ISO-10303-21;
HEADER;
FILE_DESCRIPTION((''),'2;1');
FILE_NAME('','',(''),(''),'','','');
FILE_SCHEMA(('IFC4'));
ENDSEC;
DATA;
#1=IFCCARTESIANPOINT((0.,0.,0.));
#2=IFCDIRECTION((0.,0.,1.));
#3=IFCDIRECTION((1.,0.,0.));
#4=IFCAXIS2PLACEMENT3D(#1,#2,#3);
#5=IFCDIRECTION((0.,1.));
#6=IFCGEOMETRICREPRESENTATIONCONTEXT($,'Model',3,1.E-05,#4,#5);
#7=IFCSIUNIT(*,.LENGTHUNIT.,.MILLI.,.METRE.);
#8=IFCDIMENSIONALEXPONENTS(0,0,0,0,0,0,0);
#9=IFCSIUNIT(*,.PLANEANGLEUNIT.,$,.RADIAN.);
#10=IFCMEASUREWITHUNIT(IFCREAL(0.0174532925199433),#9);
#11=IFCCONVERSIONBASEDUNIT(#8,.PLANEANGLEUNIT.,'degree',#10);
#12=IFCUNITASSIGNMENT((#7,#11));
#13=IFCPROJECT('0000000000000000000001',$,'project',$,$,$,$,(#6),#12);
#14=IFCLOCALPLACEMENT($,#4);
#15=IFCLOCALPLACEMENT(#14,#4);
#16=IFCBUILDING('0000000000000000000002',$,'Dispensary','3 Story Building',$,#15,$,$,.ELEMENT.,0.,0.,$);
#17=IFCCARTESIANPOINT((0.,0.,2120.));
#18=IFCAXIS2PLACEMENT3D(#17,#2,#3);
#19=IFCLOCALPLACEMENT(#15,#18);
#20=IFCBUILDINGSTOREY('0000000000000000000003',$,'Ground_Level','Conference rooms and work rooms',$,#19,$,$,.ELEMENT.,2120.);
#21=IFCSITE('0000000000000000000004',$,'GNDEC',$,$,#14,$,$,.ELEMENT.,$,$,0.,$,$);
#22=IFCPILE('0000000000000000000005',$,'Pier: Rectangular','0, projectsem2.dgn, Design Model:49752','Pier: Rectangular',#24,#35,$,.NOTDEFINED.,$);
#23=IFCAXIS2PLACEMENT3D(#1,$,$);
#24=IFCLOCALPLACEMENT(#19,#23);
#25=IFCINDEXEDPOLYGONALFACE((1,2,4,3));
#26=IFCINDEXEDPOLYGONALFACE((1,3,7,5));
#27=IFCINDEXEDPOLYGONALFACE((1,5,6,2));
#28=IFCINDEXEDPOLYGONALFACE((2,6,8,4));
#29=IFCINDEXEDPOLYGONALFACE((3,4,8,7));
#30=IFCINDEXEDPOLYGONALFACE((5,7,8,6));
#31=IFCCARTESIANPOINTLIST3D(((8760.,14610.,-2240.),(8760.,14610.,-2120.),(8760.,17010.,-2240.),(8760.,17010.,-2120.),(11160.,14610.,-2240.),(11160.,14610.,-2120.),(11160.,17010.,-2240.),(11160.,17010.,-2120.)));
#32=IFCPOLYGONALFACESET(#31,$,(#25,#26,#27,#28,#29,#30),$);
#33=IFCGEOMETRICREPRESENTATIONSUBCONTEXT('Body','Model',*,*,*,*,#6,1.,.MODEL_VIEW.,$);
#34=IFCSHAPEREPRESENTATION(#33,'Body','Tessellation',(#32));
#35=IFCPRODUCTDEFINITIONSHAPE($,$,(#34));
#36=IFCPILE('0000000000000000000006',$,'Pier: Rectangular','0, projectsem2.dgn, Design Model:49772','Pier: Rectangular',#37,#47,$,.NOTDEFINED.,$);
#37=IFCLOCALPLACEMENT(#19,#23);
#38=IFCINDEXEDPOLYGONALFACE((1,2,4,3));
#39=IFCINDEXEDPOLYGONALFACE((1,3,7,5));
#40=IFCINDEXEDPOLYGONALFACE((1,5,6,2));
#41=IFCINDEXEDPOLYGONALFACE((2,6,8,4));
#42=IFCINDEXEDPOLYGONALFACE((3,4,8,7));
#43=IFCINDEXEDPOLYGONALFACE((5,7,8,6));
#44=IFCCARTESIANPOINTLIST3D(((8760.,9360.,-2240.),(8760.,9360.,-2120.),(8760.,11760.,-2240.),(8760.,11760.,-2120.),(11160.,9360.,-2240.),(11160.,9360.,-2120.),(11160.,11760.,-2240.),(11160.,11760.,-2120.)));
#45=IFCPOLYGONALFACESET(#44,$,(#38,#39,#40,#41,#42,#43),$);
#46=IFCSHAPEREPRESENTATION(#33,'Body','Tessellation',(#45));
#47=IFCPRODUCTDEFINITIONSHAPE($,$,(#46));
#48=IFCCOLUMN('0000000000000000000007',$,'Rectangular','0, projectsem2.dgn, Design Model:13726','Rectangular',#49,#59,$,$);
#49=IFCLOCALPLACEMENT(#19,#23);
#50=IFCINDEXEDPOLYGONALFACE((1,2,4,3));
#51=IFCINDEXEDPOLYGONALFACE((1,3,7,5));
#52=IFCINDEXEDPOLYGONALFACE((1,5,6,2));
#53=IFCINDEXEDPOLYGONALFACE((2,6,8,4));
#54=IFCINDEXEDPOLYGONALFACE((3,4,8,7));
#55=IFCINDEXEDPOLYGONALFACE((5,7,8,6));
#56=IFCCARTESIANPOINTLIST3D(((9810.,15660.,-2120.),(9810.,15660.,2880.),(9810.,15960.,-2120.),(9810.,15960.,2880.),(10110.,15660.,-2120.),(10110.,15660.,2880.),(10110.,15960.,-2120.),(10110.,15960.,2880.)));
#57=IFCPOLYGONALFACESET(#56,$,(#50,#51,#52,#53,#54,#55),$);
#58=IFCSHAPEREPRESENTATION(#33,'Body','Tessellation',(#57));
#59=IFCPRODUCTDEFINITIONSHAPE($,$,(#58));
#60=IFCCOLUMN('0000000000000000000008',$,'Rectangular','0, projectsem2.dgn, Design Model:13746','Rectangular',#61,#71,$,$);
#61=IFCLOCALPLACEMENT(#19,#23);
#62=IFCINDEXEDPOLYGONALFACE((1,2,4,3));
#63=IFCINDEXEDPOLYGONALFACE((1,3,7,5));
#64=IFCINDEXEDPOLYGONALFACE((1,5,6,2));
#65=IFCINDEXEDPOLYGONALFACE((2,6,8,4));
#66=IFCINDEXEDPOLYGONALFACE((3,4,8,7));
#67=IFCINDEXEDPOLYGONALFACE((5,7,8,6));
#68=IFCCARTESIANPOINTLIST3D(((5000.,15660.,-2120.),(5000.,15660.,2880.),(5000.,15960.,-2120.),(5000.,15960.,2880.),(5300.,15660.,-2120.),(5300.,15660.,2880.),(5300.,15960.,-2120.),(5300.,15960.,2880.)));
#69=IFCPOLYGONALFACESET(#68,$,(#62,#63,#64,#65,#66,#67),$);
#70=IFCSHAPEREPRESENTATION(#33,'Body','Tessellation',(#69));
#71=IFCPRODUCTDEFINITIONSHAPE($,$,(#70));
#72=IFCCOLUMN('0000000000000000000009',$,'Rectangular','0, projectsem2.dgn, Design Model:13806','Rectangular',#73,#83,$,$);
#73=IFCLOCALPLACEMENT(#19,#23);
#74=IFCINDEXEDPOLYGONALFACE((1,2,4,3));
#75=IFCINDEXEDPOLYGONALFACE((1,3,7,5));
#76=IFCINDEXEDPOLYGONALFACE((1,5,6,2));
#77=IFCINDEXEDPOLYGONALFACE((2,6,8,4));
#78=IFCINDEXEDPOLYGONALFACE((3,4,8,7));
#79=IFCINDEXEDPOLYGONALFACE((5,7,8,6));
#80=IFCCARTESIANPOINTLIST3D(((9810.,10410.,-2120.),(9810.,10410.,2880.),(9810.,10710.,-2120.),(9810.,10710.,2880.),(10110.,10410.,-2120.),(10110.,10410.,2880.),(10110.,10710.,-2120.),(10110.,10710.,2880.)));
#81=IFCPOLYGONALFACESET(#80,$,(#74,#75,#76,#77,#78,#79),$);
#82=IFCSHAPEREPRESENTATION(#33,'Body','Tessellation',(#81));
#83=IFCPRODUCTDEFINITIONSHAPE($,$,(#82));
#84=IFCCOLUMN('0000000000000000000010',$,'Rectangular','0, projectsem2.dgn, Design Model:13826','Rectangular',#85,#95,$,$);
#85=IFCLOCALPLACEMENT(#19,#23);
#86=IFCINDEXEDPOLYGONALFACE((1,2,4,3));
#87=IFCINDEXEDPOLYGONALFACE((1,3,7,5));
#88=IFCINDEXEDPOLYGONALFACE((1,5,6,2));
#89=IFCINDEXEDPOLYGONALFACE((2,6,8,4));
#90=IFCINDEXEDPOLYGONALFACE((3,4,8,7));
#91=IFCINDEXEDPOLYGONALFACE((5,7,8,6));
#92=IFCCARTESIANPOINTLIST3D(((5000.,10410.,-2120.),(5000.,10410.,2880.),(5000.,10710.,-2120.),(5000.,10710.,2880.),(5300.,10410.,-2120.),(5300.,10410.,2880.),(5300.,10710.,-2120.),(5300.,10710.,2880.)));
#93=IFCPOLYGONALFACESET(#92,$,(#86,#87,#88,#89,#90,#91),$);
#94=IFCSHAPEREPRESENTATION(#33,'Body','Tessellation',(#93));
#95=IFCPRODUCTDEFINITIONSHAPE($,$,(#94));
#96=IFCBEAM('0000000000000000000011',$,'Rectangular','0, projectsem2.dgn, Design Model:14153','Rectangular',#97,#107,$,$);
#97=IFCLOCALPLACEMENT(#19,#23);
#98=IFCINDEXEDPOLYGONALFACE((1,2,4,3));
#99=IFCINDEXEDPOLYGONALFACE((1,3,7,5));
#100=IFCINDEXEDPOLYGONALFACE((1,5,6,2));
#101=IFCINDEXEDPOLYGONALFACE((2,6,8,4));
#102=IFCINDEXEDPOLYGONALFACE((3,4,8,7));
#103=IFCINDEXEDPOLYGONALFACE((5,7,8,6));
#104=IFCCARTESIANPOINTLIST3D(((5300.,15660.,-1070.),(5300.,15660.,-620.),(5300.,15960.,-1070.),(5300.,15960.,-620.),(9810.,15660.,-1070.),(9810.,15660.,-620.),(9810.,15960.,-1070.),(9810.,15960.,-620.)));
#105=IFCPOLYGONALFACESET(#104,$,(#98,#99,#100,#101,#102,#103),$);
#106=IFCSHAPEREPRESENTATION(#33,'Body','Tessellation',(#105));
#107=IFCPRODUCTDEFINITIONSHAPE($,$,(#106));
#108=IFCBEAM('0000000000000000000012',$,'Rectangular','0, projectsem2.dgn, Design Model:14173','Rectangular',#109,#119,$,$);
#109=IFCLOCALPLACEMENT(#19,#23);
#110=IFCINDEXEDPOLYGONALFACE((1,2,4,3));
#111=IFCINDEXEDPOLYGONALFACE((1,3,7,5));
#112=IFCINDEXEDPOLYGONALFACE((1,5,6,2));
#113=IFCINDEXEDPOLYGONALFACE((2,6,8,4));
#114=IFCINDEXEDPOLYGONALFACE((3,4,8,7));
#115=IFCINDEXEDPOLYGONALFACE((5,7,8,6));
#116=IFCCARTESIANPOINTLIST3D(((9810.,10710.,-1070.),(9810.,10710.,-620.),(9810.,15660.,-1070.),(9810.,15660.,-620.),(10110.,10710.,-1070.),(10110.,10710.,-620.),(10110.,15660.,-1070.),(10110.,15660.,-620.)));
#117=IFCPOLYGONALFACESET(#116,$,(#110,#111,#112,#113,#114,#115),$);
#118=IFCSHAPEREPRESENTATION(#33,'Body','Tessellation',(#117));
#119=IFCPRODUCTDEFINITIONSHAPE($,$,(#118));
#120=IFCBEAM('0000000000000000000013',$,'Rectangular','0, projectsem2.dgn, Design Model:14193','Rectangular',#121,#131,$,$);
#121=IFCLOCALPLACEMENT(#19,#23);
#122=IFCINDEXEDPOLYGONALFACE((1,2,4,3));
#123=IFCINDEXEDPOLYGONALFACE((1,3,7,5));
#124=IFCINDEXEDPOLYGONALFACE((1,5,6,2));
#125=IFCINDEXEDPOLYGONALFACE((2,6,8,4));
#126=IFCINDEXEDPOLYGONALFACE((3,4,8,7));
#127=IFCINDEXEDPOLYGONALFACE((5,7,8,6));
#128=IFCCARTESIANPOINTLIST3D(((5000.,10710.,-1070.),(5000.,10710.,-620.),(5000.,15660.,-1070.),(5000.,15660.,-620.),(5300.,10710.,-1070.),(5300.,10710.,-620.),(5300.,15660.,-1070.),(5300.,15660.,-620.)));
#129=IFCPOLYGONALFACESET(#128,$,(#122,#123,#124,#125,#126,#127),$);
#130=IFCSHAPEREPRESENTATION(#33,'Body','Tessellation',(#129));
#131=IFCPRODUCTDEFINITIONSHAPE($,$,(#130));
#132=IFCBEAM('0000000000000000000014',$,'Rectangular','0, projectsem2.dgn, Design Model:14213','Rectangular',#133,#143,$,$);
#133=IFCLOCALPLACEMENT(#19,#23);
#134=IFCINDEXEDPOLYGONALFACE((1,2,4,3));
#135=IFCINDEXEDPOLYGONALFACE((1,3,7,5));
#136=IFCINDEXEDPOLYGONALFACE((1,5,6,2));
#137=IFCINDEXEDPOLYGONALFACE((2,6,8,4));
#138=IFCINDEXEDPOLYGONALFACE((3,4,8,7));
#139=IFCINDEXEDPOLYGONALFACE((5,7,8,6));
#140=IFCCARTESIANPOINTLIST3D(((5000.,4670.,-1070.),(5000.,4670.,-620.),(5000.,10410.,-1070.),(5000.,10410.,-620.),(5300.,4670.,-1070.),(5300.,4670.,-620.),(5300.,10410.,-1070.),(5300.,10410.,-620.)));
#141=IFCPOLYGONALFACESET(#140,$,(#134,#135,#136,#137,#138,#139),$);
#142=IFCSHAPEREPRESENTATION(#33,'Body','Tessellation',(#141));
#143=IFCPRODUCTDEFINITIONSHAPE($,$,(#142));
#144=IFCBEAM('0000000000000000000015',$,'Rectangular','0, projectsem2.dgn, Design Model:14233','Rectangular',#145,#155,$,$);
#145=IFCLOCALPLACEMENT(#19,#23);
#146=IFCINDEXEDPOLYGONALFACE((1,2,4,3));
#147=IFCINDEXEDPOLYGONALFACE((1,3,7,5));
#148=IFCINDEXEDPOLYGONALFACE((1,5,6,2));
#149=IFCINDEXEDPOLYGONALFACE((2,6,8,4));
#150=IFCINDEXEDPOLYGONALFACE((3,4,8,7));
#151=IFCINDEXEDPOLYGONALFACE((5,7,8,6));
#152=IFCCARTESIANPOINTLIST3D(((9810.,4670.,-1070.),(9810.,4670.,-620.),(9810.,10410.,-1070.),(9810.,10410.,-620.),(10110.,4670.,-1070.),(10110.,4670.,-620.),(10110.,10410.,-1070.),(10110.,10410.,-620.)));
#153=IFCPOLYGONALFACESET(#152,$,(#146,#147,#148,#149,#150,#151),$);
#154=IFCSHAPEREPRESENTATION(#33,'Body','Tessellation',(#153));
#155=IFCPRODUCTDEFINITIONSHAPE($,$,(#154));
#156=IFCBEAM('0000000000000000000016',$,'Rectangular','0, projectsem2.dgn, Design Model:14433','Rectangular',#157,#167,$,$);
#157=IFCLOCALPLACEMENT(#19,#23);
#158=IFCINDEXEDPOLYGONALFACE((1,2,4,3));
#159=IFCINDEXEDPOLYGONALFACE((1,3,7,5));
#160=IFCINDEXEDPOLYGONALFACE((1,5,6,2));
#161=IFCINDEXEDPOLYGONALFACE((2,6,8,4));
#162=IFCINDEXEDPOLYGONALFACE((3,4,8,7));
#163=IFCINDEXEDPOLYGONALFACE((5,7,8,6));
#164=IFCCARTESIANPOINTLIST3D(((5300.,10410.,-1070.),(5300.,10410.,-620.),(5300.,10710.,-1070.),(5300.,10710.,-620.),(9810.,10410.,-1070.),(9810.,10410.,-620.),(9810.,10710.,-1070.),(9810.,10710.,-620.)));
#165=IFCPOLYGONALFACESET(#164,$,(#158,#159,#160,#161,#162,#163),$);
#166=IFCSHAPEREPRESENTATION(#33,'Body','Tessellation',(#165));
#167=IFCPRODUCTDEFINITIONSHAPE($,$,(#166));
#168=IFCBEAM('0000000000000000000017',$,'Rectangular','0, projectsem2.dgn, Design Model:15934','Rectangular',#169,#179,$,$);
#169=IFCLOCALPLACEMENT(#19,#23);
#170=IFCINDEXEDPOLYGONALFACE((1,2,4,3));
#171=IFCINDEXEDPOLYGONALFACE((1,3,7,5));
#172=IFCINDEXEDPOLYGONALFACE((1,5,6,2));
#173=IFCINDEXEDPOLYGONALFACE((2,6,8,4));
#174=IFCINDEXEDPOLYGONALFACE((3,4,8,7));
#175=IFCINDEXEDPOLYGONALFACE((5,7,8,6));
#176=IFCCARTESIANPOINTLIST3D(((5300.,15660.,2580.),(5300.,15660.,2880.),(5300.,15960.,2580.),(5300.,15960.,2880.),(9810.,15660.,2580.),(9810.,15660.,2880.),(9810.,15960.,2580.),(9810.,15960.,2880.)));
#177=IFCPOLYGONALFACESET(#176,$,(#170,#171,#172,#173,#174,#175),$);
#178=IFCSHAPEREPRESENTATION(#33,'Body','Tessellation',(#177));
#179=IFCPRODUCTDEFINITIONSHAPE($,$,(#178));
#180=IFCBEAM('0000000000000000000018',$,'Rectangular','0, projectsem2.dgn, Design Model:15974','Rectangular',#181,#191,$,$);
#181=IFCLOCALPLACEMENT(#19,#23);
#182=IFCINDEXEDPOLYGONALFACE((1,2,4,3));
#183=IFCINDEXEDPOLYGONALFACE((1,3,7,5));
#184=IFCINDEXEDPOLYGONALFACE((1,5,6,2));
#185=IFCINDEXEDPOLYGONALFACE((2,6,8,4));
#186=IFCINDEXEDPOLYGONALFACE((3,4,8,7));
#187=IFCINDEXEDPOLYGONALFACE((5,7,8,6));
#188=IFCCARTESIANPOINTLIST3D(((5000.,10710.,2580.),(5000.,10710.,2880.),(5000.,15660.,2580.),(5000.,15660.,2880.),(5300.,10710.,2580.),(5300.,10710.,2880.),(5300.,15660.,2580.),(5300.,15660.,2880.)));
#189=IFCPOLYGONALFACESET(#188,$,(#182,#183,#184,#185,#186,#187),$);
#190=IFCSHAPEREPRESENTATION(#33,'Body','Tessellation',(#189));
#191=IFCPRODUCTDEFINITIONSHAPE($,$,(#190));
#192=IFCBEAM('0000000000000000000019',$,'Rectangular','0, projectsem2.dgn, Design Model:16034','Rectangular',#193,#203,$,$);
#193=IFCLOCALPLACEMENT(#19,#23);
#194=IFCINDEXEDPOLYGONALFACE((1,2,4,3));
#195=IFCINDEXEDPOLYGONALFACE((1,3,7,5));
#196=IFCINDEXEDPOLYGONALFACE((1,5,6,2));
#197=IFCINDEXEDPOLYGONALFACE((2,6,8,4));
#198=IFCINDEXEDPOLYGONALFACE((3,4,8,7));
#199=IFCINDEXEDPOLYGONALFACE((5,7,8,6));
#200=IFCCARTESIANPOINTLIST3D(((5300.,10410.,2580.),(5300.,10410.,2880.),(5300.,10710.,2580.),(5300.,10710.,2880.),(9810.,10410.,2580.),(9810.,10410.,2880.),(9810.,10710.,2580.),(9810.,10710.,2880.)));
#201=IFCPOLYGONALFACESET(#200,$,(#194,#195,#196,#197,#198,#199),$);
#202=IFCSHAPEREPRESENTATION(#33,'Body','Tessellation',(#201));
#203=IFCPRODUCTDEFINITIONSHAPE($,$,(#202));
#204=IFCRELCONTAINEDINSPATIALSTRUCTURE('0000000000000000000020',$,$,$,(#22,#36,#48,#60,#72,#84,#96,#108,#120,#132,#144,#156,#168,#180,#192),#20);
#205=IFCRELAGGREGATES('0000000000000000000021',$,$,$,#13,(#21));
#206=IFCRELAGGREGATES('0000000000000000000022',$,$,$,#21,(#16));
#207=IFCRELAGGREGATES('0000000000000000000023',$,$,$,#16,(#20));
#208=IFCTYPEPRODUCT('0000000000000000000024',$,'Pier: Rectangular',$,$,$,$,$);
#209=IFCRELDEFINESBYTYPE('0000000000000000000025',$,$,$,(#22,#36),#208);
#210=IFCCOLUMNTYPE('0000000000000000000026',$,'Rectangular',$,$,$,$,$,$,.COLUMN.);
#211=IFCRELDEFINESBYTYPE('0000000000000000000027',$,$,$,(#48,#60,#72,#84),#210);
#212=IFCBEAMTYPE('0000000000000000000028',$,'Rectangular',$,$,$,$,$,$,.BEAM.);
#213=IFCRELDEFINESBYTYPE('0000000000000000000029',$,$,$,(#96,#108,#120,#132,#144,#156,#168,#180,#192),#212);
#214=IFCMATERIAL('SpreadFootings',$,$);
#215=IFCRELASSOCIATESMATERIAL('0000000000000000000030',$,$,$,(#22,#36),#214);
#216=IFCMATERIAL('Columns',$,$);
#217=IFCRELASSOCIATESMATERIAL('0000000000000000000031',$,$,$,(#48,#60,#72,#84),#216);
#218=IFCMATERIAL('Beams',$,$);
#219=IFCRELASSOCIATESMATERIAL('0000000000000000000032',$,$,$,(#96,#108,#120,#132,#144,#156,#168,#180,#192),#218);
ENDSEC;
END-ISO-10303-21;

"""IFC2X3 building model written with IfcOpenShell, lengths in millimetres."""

from ifc_helpers import new_model, entity, si_unit, converted_unit, direction, frame, frame_2d, origin_with_axes, place, context, subcontext, project, spatial, rectangle, extrude, material, type_object, element, save


model = new_model("IFC2X3")

# Units and contexts
model_context = context("Model", 3, precision=1e-05, world=origin_with_axes(), true_north=direction((0.0, 1.0)))
body_context = subcontext(model_context, "Body", "Model", "MODEL_VIEW", scale=1.0)
ifc_project = project(units=[si_unit("LENGTHUNIT", "METRE", prefix="MILLI"), converted_unit("PLANEANGLEUNIT", "degree", entity("IfcReal", 0.0174532925199433), si_unit("PLANEANGLEUNIT", "RADIAN"), dimensions=[0, 0, 0, 0, 0, 0, 0])], contexts=[model_context])

# Site, building, storey
site_placement = place(None, origin_with_axes())
site = spatial("IfcSite", under=ifc_project, at=site_placement, Name="GNDEC", CompositionType="ELEMENT", RefElevation=0.0)
building_placement = place(site_placement, origin_with_axes())
building = spatial("IfcBuilding", under=site, at=building_placement, Name="Dispensary", Description="3 Story Building", CompositionType="ELEMENT", ElevationOfRefHeight=0.0, ElevationOfTerrain=0.0)
storey_placement = place(building_placement, frame((0.0, 0.0, 2120.0), z_axis=(0.0, 0.0, 1.0), x_axis=(1.0, 0.0, 0.0)))
storey = spatial("IfcBuildingStorey", under=building, at=storey_placement, Name="Ground_Level", Description="Conference rooms and work rooms", CompositionType="ELEMENT", Elevation=2120.0)

# Piles
ifc_material_1 = material(Name="SpreadFootings")
type_product = type_object("IfcTypeProduct", Name="Pier: Rectangular")
for number, where, z_axis, x_axis, name, description in (
    (1, (8760.0, 17010.0, -2240.0), (0.0, 0.0, 1.0), (0.0, -1.0, 0.0), "Pier: Rectangular", "0, projectsem2.dgn, Design Model:49752"),
    (2, (8760.0, 11760.0, -2240.0), (0.0, 0.0, 1.0), (0.0, -1.0, 0.0), "Pier: Rectangular", "0, projectsem2.dgn, Design Model:49772"),
):
    element("IfcPile", number, at=place(storey_placement, frame(where, z_axis=z_axis, x_axis=x_axis)), inside=storey, type_object=type_product, material=ifc_material_1, Name=name, Description=description, ObjectType="Pier: Rectangular", PredefinedType="NOTDEFINED", context=body_context, shape_type="SweptSolid", body=[
        extrude(rectangle(XDim=2400.0, YDim=2400.0, at=frame_2d((1200.0, 1200.0), x_axis=(0.0, 1.0))), origin_with_axes(), (0.0, 0.0, 1.0), 120.0),
    ])

# Columns
ifc_material_2 = material(Name="Columns")
column_type = type_object("IfcColumnType", Name="Rectangular", PredefinedType="COLUMN")
for number, where, z_axis, x_axis, name, description in (
    (3, (9810.0, 15960.0, -2120.0), (0.0, 0.0, 1.0), (0.0, -1.0, 0.0), "Rectangular", "0, projectsem2.dgn, Design Model:13726"),
    (4, (5000.0, 15960.0, -2120.0), (0.0, 0.0, 1.0), (0.0, -1.0, 0.0), "Rectangular", "0, projectsem2.dgn, Design Model:13746"),
    (5, (9810.0, 10710.0, -2120.0), (0.0, 0.0, 1.0), (0.0, -1.0, 0.0), "Rectangular", "0, projectsem2.dgn, Design Model:13806"),
    (6, (5000.0, 10710.0, -2120.0), (0.0, 0.0, 1.0), (0.0, -1.0, 0.0), "Rectangular", "0, projectsem2.dgn, Design Model:13826"),
):
    element("IfcColumn", number, at=place(storey_placement, frame(where, z_axis=z_axis, x_axis=x_axis)), inside=storey, type_object=column_type, material=ifc_material_2, Name=name, Description=description, ObjectType="Rectangular", context=body_context, shape_type="SweptSolid", body=[
        extrude(rectangle(XDim=300.0, YDim=300.0, at=frame_2d((150.0, 150.0), x_axis=(0.0, 1.0))), origin_with_axes(), (0.0, 0.0, 1.0), 5000.0),
    ])

# Beams
ifc_material_3 = material(Name="Beams")
beam_type = type_object("IfcBeamType", Name="Rectangular", PredefinedType="BEAM")
beam_1_placement = place(storey_placement, frame((5300.0, 15960.0, -1070.0), z_axis=(1.0, 0.0, 0.0), x_axis=(0.0, 0.0, 1.0)))
element("IfcBeam", 7, at=beam_1_placement, inside=storey, type_object=beam_type, material=ifc_material_3, Name="Rectangular", Description="0, projectsem2.dgn, Design Model:14153", ObjectType="Rectangular", context=body_context, shape_type="SweptSolid", body=[
    extrude(rectangle(XDim=300.0, YDim=450.0, at=frame_2d((225.0, 150.0), x_axis=(0.0, 1.0))), origin_with_axes(), (0.0, 0.0, 1.0), 4510.0),
])
for number, where, z_axis, x_axis, name, description in (
    (8, (10110.0, 15660.0, -1070.0), (0.0, -1.0, 0.0), (0.0, 0.0, 1.0), "Rectangular", "0, projectsem2.dgn, Design Model:14173"),
    (9, (5300.0, 15660.0, -1070.0), (0.0, -1.0, 0.0), (0.0, 0.0, 1.0), "Rectangular", "0, projectsem2.dgn, Design Model:14193"),
):
    element("IfcBeam", number, at=place(storey_placement, frame(where, z_axis=z_axis, x_axis=x_axis)), inside=storey, type_object=beam_type, material=ifc_material_3, Name=name, Description=description, ObjectType="Rectangular", context=body_context, shape_type="SweptSolid", body=[
        extrude(rectangle(XDim=300.0, YDim=450.0, at=frame_2d((225.0, 150.0), x_axis=(0.0, 1.0))), origin_with_axes(), (0.0, 0.0, 1.0), 4950.0),
    ])
for number, where, z_axis, x_axis, name, description in (
    (10, (5300.0, 10410.0, -1070.0), (0.0, -1.0, 0.0), (0.0, 0.0, 1.0), "Rectangular", "0, projectsem2.dgn, Design Model:14213"),
    (11, (10110.0, 10410.0, -1070.0), (0.0, -1.0, 0.0), (0.0, 0.0, 1.0), "Rectangular", "0, projectsem2.dgn, Design Model:14233"),
):
    element("IfcBeam", number, at=place(storey_placement, frame(where, z_axis=z_axis, x_axis=x_axis)), inside=storey, type_object=beam_type, material=ifc_material_3, Name=name, Description=description, ObjectType="Rectangular", context=body_context, shape_type="SweptSolid", body=[
        extrude(rectangle(XDim=300.0, YDim=450.0, at=frame_2d((225.0, 150.0), x_axis=(0.0, 1.0))), origin_with_axes(), (0.0, 0.0, 1.0), 5740.0),
    ])
beam_2_placement = place(storey_placement, frame((9810.0, 10410.0, -1070.0), z_axis=(-1.0, 0.0, 0.0), x_axis=(0.0, 0.0, 1.0)))
element("IfcBeam", 12, at=beam_2_placement, inside=storey, type_object=beam_type, material=ifc_material_3, Name="Rectangular", Description="0, projectsem2.dgn, Design Model:14433", ObjectType="Rectangular", context=body_context, shape_type="SweptSolid", body=[
    extrude(rectangle(XDim=300.0, YDim=450.0, at=frame_2d((225.0, 150.0), x_axis=(0.0, 1.0))), origin_with_axes(), (0.0, 0.0, 1.0), 4510.0),
])
beam_3_placement = place(storey_placement, frame((5300.0, 15960.0, 2580.0), z_axis=(1.0, 0.0, 0.0), x_axis=(0.0, 0.0, 1.0)))
element("IfcBeam", 13, at=beam_3_placement, inside=storey, type_object=beam_type, material=ifc_material_3, Name="Rectangular", Description="0, projectsem2.dgn, Design Model:15934", ObjectType="Rectangular", context=body_context, shape_type="SweptSolid", body=[
    extrude(rectangle(XDim=300.0, YDim=300.0, at=frame_2d((150.0, 150.0), x_axis=(0.0, 1.0))), origin_with_axes(), (0.0, 0.0, 1.0), 4510.0),
])
beam_4_placement = place(storey_placement, frame((5300.0, 15660.0, 2580.0), z_axis=(0.0, -1.0, 0.0), x_axis=(0.0, 0.0, 1.0)))
element("IfcBeam", 14, at=beam_4_placement, inside=storey, type_object=beam_type, material=ifc_material_3, Name="Rectangular", Description="0, projectsem2.dgn, Design Model:15974", ObjectType="Rectangular", context=body_context, shape_type="SweptSolid", body=[
    extrude(rectangle(XDim=300.0, YDim=300.0, at=frame_2d((150.0, 150.0), x_axis=(0.0, 1.0))), origin_with_axes(), (0.0, 0.0, 1.0), 4950.0),
])
for number, where, z_axis, x_axis, name in (
    (15, (5300.0, 10710.0, 2580.0), (1.0, 0.0, 0.0), (0.0, 0.0, 1.0), "Rectangular"),
):
    element("IfcBeam", number, at=place(storey_placement, frame(where, z_axis=z_axis, x_axis=x_axis)), inside=storey, type_object=beam_type, material=ifc_material_3, Name=name, Description="0, projectsem2.dgn, Design Model:16034", ObjectType="Rectangular", context=body_context, shape_type="SweptSolid", body=[
        extrude(rectangle(XDim=300.0, YDim=300.0, at=frame_2d((150.0, 150.0), x_axis=(0.0, 1.0))), origin_with_axes(), (0.0, 0.0, 1.0), 4510.0),
    ])

save(model, "model.ifc")
